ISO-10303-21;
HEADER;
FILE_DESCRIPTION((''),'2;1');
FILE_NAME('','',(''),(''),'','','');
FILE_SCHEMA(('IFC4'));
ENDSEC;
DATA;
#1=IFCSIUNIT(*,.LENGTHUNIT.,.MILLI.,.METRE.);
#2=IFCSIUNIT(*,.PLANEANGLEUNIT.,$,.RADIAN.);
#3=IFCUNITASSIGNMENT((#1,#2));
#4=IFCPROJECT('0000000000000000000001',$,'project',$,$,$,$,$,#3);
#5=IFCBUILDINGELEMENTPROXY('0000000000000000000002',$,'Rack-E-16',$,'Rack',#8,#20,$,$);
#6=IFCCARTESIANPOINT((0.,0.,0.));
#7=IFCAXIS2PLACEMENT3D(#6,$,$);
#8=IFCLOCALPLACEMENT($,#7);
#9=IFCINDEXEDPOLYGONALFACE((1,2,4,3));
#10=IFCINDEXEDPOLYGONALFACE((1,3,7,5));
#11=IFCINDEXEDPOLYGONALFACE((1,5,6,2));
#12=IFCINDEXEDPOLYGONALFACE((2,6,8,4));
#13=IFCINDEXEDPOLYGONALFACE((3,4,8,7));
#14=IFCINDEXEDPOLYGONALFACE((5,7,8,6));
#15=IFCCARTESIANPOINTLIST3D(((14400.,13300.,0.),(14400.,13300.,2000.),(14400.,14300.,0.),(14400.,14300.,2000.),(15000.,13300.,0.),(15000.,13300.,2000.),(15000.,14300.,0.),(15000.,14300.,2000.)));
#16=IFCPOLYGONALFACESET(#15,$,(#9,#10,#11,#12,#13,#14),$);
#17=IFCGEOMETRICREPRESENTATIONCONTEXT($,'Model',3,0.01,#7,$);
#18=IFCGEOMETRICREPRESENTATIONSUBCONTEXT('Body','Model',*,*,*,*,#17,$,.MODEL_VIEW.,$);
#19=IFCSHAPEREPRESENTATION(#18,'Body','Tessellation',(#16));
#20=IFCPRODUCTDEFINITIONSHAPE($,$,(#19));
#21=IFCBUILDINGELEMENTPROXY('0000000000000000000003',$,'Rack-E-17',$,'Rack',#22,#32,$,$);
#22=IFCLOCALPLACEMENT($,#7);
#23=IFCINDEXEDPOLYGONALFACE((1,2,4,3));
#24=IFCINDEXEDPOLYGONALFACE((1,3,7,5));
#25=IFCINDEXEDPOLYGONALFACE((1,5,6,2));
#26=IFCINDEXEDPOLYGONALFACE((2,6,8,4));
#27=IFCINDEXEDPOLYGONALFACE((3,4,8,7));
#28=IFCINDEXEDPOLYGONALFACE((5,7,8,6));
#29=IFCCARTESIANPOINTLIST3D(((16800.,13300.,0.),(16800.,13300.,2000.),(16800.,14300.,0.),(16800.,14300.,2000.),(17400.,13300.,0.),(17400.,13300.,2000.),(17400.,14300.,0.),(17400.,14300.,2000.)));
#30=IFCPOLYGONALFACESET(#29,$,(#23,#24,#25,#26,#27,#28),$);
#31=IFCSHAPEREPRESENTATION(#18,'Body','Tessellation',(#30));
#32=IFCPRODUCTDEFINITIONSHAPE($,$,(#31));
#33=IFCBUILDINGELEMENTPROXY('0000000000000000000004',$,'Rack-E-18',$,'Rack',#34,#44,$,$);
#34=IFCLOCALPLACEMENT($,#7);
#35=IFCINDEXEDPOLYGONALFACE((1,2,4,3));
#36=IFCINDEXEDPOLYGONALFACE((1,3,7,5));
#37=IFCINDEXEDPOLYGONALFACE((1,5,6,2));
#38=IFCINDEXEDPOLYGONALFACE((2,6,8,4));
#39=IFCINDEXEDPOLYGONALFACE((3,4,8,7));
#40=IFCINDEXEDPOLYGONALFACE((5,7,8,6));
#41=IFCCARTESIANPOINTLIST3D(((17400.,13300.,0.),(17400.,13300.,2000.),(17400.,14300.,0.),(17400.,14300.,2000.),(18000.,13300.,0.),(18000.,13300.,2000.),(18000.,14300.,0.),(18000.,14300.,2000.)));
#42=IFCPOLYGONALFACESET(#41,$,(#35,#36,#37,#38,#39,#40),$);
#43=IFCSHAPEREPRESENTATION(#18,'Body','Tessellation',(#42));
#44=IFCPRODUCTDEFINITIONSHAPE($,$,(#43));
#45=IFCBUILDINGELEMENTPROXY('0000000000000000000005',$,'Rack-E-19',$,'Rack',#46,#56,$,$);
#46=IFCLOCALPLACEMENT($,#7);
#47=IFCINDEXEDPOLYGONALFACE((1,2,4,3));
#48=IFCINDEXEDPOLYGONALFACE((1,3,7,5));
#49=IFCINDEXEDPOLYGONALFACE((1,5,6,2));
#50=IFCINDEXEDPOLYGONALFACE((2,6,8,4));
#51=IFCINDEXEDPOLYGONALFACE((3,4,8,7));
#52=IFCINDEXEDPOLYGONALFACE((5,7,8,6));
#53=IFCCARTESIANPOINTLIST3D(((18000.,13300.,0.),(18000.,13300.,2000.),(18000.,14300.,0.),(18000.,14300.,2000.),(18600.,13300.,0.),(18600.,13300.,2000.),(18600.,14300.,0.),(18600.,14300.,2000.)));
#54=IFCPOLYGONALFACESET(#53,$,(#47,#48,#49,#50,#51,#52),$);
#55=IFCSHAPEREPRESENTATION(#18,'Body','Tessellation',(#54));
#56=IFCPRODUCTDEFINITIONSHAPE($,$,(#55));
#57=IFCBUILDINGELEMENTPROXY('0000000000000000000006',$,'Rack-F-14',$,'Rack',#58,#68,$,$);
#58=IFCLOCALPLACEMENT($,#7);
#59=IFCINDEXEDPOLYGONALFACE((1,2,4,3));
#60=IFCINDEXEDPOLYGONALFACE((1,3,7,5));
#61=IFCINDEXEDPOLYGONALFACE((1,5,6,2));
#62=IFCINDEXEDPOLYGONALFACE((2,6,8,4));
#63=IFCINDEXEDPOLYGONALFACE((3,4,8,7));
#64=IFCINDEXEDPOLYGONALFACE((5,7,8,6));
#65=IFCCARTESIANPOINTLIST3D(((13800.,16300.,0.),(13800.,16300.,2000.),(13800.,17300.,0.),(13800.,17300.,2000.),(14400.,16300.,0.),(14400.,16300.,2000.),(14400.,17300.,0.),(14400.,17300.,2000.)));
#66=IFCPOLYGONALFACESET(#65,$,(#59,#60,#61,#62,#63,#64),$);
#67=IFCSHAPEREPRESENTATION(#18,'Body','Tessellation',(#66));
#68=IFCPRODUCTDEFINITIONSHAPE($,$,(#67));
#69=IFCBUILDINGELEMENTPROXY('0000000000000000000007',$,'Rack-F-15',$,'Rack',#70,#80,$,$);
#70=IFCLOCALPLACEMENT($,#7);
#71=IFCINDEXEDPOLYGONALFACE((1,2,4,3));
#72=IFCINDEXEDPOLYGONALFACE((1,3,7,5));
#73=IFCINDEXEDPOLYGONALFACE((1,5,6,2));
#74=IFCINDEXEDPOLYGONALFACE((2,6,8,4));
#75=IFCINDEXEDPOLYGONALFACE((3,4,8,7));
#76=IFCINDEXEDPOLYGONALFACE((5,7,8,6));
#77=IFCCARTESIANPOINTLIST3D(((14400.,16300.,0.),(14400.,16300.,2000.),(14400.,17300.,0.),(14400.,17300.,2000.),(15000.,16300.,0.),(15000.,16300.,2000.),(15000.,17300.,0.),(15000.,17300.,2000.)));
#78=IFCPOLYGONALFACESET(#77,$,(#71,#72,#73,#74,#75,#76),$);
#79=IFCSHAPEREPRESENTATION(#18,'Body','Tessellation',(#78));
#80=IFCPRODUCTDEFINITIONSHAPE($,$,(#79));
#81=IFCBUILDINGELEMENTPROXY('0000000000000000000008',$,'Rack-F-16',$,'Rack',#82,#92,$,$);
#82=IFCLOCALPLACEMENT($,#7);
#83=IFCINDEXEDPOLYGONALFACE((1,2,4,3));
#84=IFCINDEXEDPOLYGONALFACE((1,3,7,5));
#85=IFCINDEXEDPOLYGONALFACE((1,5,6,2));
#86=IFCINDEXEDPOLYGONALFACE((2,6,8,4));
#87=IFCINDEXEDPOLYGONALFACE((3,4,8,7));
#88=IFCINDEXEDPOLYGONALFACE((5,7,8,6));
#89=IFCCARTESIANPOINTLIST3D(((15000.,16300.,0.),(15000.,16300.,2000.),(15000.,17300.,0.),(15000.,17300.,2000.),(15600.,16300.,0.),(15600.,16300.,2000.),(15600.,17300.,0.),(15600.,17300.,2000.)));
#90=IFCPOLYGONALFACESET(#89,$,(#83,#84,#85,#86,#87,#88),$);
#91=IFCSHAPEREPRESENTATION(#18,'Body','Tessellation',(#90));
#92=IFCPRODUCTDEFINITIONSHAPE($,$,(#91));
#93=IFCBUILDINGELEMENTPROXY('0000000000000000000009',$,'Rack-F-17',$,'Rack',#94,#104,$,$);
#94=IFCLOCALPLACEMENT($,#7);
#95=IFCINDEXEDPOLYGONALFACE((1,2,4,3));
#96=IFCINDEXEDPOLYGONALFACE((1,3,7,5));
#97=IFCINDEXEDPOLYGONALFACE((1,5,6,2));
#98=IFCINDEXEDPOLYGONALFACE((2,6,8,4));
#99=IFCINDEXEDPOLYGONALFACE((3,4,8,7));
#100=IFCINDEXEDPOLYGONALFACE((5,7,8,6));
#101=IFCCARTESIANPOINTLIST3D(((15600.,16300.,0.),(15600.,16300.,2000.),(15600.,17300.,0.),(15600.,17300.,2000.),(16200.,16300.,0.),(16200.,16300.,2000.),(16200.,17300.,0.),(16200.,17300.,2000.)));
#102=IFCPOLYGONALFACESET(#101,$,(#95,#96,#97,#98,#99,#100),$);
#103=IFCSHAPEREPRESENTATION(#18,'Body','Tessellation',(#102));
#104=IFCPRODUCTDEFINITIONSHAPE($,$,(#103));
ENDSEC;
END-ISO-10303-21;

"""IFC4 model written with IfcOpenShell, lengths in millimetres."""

from ifc_helpers import new_model, si_unit, frame, origin, place, context, subcontext, project, rectangle, extrude, element, save


model = new_model("IFC4")

# Units and contexts
model_context = context("Model", 3, precision=0.01, world=origin())
body_context = subcontext(model_context, "Body", "Model", "MODEL_VIEW")
ifc_project = project(units=[si_unit("LENGTHUNIT", "METRE", prefix="MILLI"), si_unit("PLANEANGLEUNIT", "RADIAN")])

# Shared definitions
placement = place(None, origin())

# Building element proxies
for number, where, name in (
    (1, (14700.0, 13800.0, 0.0), "Rack-E-16"),
    (2, (17100.0, 13800.0, 0.0), "Rack-E-17"),
    (3, (17700.0, 13800.0, 0.0), "Rack-E-18"),
    (4, (18300.0, 13800.0, 0.0), "Rack-E-19"),
    (5, (14100.0, 16800.0, 0.0), "Rack-F-14"),
    (6, (14700.0, 16800.0, 0.0), "Rack-F-15"),
    (7, (15300.0, 16800.0, 0.0), "Rack-F-16"),
    (8, (15900.0, 16800.0, 0.0), "Rack-F-17"),
):
    element("IfcBuildingElementProxy", number, at=place(placement, frame(where)), Name=name, ObjectType="Rack", context=body_context, shape_type="SweptSolid", body=[
        extrude(rectangle(XDim=600.0, YDim=1000.0), origin(), (0.0, 0.0, 1.0), 2000.0),
    ])

save(model, "model.ifc")
